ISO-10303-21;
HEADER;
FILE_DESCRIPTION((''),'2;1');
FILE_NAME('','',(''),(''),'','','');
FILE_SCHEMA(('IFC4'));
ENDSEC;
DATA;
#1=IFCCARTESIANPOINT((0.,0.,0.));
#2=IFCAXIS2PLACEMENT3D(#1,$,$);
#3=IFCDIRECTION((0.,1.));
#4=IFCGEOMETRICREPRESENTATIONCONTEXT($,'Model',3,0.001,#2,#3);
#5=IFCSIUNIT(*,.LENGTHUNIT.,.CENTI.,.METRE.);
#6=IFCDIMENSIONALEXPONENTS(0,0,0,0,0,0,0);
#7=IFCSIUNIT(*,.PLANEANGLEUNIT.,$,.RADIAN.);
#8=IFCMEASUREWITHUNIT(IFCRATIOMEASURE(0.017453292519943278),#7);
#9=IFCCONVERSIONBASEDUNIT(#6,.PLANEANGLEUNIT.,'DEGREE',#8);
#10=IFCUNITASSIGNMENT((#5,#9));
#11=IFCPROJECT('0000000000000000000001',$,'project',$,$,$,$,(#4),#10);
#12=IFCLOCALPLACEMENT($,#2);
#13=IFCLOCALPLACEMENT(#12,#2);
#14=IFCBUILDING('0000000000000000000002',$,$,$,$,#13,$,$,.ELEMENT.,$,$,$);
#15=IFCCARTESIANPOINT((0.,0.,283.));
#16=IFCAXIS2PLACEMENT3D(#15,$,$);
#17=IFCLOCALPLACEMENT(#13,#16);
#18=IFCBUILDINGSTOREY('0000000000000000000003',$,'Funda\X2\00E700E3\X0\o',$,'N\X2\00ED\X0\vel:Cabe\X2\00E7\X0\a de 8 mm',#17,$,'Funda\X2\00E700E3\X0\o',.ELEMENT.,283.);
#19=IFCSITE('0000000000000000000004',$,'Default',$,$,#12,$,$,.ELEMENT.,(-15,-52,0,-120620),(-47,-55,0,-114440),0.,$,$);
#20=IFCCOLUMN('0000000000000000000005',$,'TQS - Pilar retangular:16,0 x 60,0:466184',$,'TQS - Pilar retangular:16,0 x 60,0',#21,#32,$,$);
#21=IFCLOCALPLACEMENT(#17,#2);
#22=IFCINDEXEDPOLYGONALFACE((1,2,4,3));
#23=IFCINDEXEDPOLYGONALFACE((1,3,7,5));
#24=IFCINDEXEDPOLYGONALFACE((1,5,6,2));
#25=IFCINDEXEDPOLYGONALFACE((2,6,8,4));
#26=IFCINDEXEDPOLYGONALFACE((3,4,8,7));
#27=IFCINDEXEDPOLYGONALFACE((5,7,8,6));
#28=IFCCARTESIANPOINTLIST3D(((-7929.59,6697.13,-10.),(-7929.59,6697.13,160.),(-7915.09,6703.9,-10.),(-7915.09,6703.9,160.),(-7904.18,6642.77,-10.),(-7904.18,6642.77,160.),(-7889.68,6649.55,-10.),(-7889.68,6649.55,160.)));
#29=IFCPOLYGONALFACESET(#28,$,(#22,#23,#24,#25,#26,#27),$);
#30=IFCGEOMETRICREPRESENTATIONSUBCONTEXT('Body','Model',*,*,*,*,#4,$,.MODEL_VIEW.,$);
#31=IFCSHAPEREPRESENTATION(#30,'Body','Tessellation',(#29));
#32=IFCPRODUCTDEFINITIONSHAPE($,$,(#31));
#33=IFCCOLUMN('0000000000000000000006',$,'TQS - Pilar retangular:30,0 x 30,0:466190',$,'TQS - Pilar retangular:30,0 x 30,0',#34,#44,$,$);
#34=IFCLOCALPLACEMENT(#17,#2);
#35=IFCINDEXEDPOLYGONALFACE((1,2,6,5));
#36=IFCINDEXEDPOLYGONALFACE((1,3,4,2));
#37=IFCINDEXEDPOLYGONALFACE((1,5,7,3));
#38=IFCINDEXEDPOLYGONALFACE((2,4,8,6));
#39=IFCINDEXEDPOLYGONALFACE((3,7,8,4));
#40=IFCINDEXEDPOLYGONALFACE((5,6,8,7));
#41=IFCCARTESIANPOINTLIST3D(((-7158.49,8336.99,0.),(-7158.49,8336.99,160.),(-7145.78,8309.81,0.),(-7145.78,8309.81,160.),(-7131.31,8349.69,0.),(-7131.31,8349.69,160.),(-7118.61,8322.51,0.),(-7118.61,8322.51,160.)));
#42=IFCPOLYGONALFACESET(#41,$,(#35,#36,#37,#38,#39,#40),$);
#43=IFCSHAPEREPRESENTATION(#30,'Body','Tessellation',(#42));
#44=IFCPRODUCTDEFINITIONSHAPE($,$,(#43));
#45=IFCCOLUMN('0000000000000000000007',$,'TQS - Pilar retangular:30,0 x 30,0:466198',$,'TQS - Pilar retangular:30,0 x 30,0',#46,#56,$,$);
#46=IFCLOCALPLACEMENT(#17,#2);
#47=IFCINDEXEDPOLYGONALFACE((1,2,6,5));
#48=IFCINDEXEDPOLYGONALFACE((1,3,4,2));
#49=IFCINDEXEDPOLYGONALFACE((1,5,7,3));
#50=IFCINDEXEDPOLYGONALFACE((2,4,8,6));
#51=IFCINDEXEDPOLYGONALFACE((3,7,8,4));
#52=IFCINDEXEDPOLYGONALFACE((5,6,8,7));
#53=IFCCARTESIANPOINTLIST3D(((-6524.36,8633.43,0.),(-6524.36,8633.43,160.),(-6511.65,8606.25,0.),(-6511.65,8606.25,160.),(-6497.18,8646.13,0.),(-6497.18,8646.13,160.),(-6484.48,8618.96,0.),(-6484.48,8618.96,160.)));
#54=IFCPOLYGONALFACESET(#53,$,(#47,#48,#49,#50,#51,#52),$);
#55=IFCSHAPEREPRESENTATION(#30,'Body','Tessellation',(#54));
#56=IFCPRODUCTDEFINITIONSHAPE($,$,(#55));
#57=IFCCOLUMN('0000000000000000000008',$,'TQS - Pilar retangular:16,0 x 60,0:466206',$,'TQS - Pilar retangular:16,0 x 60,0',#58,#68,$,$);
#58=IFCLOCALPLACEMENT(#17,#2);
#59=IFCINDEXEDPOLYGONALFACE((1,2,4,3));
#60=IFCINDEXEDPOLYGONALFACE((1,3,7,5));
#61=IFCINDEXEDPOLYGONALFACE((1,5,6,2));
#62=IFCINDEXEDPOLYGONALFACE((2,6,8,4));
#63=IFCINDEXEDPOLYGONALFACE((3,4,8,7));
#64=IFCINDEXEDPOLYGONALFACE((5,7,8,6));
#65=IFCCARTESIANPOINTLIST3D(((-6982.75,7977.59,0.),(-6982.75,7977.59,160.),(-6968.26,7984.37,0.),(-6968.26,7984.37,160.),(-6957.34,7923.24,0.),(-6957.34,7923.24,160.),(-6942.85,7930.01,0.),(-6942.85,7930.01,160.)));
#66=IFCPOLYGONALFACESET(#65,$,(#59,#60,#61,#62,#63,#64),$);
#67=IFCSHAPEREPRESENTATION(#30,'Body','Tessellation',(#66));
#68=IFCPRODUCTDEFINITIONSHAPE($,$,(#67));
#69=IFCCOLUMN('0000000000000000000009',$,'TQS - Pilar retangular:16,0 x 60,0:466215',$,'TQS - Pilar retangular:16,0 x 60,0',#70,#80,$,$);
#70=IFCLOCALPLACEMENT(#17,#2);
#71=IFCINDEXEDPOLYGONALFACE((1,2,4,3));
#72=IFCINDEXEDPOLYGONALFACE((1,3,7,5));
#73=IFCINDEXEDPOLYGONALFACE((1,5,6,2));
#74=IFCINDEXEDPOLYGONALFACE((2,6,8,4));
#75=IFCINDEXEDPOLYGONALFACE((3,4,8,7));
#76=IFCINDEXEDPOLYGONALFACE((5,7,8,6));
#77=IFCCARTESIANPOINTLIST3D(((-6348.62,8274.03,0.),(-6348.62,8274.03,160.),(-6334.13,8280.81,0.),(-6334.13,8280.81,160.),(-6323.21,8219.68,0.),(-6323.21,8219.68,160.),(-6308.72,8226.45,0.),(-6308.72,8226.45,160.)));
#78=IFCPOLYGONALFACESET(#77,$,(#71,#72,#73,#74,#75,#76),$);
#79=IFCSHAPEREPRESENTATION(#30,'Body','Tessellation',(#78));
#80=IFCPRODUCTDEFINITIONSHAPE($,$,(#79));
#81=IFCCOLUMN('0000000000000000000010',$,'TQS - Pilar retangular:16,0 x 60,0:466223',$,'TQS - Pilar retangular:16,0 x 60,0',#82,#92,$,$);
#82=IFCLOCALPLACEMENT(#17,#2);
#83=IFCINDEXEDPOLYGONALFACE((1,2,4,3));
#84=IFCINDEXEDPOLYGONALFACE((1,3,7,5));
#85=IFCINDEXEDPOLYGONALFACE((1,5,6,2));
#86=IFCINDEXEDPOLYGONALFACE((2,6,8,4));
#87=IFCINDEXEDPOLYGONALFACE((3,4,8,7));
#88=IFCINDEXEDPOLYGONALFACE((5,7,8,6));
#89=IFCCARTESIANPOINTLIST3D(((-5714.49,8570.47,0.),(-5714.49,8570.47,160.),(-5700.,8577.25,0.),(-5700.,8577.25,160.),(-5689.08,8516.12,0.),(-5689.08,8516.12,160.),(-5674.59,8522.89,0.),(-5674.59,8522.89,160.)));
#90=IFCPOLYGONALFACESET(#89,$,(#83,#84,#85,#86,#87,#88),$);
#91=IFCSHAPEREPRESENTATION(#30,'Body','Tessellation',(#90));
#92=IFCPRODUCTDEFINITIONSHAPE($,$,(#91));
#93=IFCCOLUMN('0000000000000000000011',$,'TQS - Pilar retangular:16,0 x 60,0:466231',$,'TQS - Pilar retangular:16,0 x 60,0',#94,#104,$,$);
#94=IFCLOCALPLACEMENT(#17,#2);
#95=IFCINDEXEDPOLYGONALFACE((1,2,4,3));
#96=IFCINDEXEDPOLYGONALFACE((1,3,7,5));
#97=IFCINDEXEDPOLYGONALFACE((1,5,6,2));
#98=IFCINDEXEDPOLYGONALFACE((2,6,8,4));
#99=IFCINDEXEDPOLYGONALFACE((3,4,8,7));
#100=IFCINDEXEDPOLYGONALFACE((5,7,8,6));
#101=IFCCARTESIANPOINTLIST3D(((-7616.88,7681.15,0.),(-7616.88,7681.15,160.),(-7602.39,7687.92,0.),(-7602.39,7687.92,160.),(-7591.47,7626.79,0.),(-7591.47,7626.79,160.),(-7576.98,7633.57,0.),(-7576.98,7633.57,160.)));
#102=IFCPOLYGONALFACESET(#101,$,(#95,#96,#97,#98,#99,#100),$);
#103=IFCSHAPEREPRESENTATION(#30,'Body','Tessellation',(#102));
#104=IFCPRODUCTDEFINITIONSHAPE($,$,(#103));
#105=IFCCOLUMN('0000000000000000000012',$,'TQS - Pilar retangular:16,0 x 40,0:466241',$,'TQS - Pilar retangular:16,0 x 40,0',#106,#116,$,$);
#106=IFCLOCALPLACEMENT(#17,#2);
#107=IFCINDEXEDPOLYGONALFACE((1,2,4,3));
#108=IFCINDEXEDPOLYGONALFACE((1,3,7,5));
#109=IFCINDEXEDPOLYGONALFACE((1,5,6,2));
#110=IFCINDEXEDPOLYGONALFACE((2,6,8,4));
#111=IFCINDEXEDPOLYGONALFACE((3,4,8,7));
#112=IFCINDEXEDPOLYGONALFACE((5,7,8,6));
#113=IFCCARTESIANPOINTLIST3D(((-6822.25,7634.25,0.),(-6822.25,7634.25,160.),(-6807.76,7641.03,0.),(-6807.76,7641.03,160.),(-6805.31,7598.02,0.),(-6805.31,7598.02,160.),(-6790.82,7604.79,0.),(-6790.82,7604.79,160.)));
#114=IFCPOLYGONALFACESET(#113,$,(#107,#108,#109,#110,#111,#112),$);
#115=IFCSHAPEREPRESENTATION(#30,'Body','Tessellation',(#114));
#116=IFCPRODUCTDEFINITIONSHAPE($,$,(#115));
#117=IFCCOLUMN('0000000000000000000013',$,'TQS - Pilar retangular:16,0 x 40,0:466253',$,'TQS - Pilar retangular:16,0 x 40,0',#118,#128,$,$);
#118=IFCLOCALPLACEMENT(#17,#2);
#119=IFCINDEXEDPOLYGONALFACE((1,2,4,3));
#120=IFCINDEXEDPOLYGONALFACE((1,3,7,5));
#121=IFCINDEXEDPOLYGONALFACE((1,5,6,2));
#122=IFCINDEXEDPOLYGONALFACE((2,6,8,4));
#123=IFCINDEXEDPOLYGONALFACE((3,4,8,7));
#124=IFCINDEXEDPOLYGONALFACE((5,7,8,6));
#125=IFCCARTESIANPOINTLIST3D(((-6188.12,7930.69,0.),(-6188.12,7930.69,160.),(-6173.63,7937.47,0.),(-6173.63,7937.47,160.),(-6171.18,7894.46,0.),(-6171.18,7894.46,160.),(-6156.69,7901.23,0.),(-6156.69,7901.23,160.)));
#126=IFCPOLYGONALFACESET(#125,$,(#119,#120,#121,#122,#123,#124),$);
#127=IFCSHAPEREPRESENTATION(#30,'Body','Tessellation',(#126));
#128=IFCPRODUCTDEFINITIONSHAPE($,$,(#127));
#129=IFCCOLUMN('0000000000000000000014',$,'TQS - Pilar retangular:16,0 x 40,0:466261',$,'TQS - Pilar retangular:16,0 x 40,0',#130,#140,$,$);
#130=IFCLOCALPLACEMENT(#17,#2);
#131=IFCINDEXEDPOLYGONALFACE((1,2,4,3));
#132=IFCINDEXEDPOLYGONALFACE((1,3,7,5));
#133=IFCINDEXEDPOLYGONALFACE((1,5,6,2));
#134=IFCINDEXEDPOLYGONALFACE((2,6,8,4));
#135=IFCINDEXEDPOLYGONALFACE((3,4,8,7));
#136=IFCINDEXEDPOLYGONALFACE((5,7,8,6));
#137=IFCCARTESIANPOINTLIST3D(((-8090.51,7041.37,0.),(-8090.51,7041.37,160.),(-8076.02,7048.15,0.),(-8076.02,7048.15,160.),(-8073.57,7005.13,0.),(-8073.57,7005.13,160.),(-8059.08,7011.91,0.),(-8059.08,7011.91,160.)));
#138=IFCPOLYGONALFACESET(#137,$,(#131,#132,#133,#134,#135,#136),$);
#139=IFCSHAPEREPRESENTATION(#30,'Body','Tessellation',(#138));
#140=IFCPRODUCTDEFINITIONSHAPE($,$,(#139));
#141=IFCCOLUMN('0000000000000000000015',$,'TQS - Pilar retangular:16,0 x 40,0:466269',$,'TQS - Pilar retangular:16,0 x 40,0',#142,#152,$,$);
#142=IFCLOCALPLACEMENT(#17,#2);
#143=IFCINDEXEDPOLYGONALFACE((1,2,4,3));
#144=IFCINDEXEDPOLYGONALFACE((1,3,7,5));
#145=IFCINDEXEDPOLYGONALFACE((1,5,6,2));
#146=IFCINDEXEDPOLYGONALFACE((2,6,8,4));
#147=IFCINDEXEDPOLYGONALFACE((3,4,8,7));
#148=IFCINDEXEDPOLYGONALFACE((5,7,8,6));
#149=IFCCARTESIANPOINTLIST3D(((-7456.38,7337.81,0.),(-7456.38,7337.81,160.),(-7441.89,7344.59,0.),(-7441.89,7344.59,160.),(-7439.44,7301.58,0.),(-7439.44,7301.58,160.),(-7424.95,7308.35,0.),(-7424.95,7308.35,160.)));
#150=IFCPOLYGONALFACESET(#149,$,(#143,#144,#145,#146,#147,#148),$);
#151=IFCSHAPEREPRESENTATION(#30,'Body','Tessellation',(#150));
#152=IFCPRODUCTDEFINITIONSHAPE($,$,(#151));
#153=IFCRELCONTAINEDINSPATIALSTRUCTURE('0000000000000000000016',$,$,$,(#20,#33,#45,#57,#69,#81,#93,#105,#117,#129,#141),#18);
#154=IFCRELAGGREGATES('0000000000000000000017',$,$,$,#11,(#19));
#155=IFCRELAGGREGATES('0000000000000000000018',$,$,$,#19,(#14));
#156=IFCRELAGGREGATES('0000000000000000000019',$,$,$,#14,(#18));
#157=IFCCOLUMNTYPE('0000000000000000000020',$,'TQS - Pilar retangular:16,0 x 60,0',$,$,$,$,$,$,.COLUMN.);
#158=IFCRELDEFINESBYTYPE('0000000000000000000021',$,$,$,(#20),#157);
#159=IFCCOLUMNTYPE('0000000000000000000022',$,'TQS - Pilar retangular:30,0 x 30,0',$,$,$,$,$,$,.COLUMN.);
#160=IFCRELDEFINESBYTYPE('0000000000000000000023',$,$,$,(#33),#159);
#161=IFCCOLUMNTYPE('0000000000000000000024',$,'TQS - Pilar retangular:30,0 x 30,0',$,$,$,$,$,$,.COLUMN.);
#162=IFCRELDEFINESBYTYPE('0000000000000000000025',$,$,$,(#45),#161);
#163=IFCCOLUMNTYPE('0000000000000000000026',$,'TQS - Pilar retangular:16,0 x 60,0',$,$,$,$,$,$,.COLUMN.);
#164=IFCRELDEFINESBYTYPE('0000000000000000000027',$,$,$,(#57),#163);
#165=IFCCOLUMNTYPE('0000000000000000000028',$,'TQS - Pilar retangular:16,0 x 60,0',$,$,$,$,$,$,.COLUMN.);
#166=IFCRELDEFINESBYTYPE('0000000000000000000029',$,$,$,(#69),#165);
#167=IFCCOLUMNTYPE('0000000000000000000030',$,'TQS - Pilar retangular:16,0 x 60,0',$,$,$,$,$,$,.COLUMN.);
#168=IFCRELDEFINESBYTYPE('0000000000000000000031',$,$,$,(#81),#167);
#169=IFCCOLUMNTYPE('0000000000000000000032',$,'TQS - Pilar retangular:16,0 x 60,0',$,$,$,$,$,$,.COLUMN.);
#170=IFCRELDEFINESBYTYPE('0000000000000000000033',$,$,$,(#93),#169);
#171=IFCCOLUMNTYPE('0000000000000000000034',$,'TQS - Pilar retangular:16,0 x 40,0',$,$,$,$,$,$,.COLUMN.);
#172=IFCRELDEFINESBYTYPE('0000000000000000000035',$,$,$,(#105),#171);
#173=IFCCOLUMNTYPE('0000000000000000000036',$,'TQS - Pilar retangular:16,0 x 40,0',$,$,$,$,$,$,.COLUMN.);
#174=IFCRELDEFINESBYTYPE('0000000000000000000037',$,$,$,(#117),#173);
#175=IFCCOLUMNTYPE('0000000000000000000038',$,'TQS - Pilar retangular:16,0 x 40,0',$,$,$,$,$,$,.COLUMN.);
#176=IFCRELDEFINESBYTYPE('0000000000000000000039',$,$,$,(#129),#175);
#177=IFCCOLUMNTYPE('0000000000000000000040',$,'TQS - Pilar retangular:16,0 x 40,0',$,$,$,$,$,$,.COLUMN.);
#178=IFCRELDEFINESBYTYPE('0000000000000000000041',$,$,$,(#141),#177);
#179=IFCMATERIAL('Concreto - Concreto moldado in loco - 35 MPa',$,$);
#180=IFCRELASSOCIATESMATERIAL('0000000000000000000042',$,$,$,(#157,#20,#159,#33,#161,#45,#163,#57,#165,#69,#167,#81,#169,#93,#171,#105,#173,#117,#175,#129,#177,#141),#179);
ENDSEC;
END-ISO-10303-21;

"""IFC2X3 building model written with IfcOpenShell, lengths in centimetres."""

from ifc_helpers import new_model, entity, si_unit, converted_unit, direction, frame, frame_2d, origin, origin_2d_with_axis, place, context, subcontext, project, spatial, rectangle, extrude, source, transform, mapped, material, type_object, type_shapes, element, save


model = new_model("IFC2X3")

# Units and contexts
model_context = context("Model", 3, precision=0.001, world=origin(), true_north=direction((0.0, 1.0)))
body_context = subcontext(model_context, "Body", "Model", "MODEL_VIEW")
ifc_project = project(units=[si_unit("LENGTHUNIT", "METRE", prefix="CENTI"), converted_unit("PLANEANGLEUNIT", "DEGREE", entity("IfcRatioMeasure", 0.017453292519943278), si_unit("PLANEANGLEUNIT", "RADIAN"), dimensions=[0, 0, 0, 0, 0, 0, 0])], contexts=[model_context])

# Site, building, storey
site_placement = place(None, origin())
site = spatial("IfcSite", under=ifc_project, at=site_placement, Name="Default", CompositionType="ELEMENT", RefLatitude=(-15, -52, 0, -120620), RefLongitude=(-47, -55, 0, -114440), RefElevation=0.0)
building_placement = place(site_placement, origin())
building = spatial("IfcBuilding", under=site, at=building_placement, CompositionType="ELEMENT")
storey_placement = place(building_placement, frame((0.0, 0.0, 283.0)))
storey = spatial("IfcBuildingStorey", under=building, at=storey_placement, Name="Fundação", ObjectType="Nível:Cabeça de 8 mm", LongName="Fundação", CompositionType="ELEMENT", Elevation=283.0)

# Columns
ifc_material_1 = material(Name="Concreto - Concreto moldado in loco - 35 MPa")
column_type_1 = type_object("IfcColumnType", Name="TQS - Pilar retangular:16,0 x 60,0", PredefinedType="COLUMN", material=ifc_material_1)
shared_shape_1 = source(origin(), body_context, "Body", "SweptSolid", [
    extrude(rectangle(XDim=60.0, YDim=16.0, at=origin_2d_with_axis()), frame((-7909.64, 6673.34, 273.0), z_axis=(0.0, 0.0, 1.0), x_axis=(-0.423488, 0.905902, 0.0)), (0.0, 0.0, 1.0), 170.0),
])
type_shapes(column_type_1, [shared_shape_1])
column_1_placement = place(storey_placement, frame((0.0, 0.0, -283.0)))
element("IfcColumn", 1, at=column_1_placement, inside=storey, type_object=column_type_1, material=ifc_material_1, Name="TQS - Pilar retangular:16,0 x 60,0:466184", ObjectType="TQS - Pilar retangular:16,0 x 60,0", context=body_context, shape_type="MappedRepresentation", body=[
    mapped(shared_shape_1, transform((0.0, 0.0, 0.0), scale=1.0)),
])
column_type_2 = type_object("IfcColumnType", Name="TQS - Pilar retangular:30,0 x 30,0", PredefinedType="COLUMN", material=ifc_material_1)
shared_shape_2 = source(origin(), body_context, "Body", "SweptSolid", [
    extrude(rectangle(XDim=30.0, YDim=30.0, at=origin_2d_with_axis()), frame((-7138.55, 8329.75, 283.0), z_axis=(0.0, 0.0, 1.0), x_axis=(-0.423488, 0.905902, 0.0)), (0.0, 0.0, 1.0), 160.0),
])
type_shapes(column_type_2, [shared_shape_2])
column_2_placement = place(storey_placement, frame((0.0, 0.0, -283.0)))
element("IfcColumn", 2, at=column_2_placement, inside=storey, type_object=column_type_2, material=ifc_material_1, Name="TQS - Pilar retangular:30,0 x 30,0:466190", ObjectType="TQS - Pilar retangular:30,0 x 30,0", context=body_context, shape_type="MappedRepresentation", body=[
    mapped(shared_shape_2, transform((0.0, 0.0, 0.0), scale=1.0)),
])
column_type_3 = type_object("IfcColumnType", Name="TQS - Pilar retangular:30,0 x 30,0", PredefinedType="COLUMN", material=ifc_material_1)
shared_shape_3 = source(origin(), body_context, "Body", "SweptSolid", [
    extrude(rectangle(XDim=30.0, YDim=30.0, at=origin_2d_with_axis()), frame((-6504.42, 8626.19, 283.0), z_axis=(0.0, 0.0, 1.0), x_axis=(-0.423488, 0.905902, 0.0)), (0.0, 0.0, 1.0), 160.0),
])
type_shapes(column_type_3, [shared_shape_3])
column_3_placement = place(storey_placement, frame((0.0, 0.0, -283.0)))
element("IfcColumn", 3, at=column_3_placement, inside=storey, type_object=column_type_3, material=ifc_material_1, Name="TQS - Pilar retangular:30,0 x 30,0:466198", ObjectType="TQS - Pilar retangular:30,0 x 30,0", context=body_context, shape_type="MappedRepresentation", body=[
    mapped(shared_shape_3, transform((0.0, 0.0, 0.0), scale=1.0)),
])
column_type_4 = type_object("IfcColumnType", Name="TQS - Pilar retangular:16,0 x 60,0", PredefinedType="COLUMN", material=ifc_material_1)
shared_shape_4 = source(origin(), body_context, "Body", "SweptSolid", [
    extrude(rectangle(XDim=60.0, YDim=16.0, at=frame_2d((0.0, 0.0), x_axis=(1.0, 0.0))), frame((-6962.8, 7953.8, 283.0), z_axis=(0.0, 0.0, 1.0), x_axis=(-0.423488, 0.905902, 0.0)), (0.0, 0.0, 1.0), 160.0),
])
type_shapes(column_type_4, [shared_shape_4])
column_4_placement = place(storey_placement, frame((0.0, 0.0, -283.0)))
element("IfcColumn", 4, at=column_4_placement, inside=storey, type_object=column_type_4, material=ifc_material_1, Name="TQS - Pilar retangular:16,0 x 60,0:466206", ObjectType="TQS - Pilar retangular:16,0 x 60,0", context=body_context, shape_type="MappedRepresentation", body=[
    mapped(shared_shape_4, transform((0.0, 0.0, 0.0), scale=1.0)),
])
column_type_5 = type_object("IfcColumnType", Name="TQS - Pilar retangular:16,0 x 60,0", PredefinedType="COLUMN", material=ifc_material_1)
shared_shape_5 = source(origin(), body_context, "Body", "SweptSolid", [
    extrude(rectangle(XDim=60.0, YDim=16.0, at=origin_2d_with_axis()), frame((-6328.67, 8250.24, 283.0), z_axis=(0.0, 0.0, 1.0), x_axis=(-0.423488, 0.905902, 0.0)), (0.0, 0.0, 1.0), 160.0),
])
type_shapes(column_type_5, [shared_shape_5])
column_5_placement = place(storey_placement, frame((0.0, 0.0, -283.0)))
element("IfcColumn", 5, at=column_5_placement, inside=storey, type_object=column_type_5, material=ifc_material_1, Name="TQS - Pilar retangular:16,0 x 60,0:466215", ObjectType="TQS - Pilar retangular:16,0 x 60,0", context=body_context, shape_type="MappedRepresentation", body=[
    mapped(shared_shape_5, transform((0.0, 0.0, 0.0), scale=1.0)),
])
column_type_6 = type_object("IfcColumnType", Name="TQS - Pilar retangular:16,0 x 60,0", PredefinedType="COLUMN", material=ifc_material_1)
shared_shape_6 = source(origin(), body_context, "Body", "SweptSolid", [
    extrude(rectangle(XDim=60.0, YDim=16.0, at=frame_2d((0.0, 0.0), x_axis=(1.0, 0.0))), frame((-5694.54, 8546.68, 283.0), z_axis=(0.0, 0.0, 1.0), x_axis=(-0.423488, 0.905902, 0.0)), (0.0, 0.0, 1.0), 160.0),
])
type_shapes(column_type_6, [shared_shape_6])
column_6_placement = place(storey_placement, frame((0.0, 0.0, -283.0)))
element("IfcColumn", 6, at=column_6_placement, inside=storey, type_object=column_type_6, material=ifc_material_1, Name="TQS - Pilar retangular:16,0 x 60,0:466223", ObjectType="TQS - Pilar retangular:16,0 x 60,0", context=body_context, shape_type="MappedRepresentation", body=[
    mapped(shared_shape_6, transform((0.0, 0.0, 0.0), scale=1.0)),
])
column_type_7 = type_object("IfcColumnType", Name="TQS - Pilar retangular:16,0 x 60,0", PredefinedType="COLUMN", material=ifc_material_1)
shared_shape_7 = source(origin(), body_context, "Body", "SweptSolid", [
    extrude(rectangle(XDim=60.0, YDim=16.0, at=frame_2d((0.0, 0.0), x_axis=(1.0, 0.0))), frame((-7596.93, 7657.36, 283.0), z_axis=(0.0, 0.0, 1.0), x_axis=(-0.423488, 0.905902, 0.0)), (0.0, 0.0, 1.0), 160.0),
])
type_shapes(column_type_7, [shared_shape_7])
column_7_placement = place(storey_placement, frame((0.0, 0.0, -283.0)))
element("IfcColumn", 7, at=column_7_placement, inside=storey, type_object=column_type_7, material=ifc_material_1, Name="TQS - Pilar retangular:16,0 x 60,0:466231", ObjectType="TQS - Pilar retangular:16,0 x 60,0", context=body_context, shape_type="MappedRepresentation", body=[
    mapped(shared_shape_7, transform((0.0, 0.0, 0.0), scale=1.0)),
])
column_type_8 = type_object("IfcColumnType", Name="TQS - Pilar retangular:16,0 x 40,0", PredefinedType="COLUMN", material=ifc_material_1)
shared_shape_8 = source(origin(), body_context, "Body", "SweptSolid", [
    extrude(rectangle(XDim=40.0, YDim=16.0, at=origin_2d_with_axis()), frame((-6806.53, 7619.52, 283.0), z_axis=(0.0, 0.0, 1.0), x_axis=(-0.423488, 0.905902, 0.0)), (0.0, 0.0, 1.0), 160.0),
])
type_shapes(column_type_8, [shared_shape_8])
column_8_placement = place(storey_placement, frame((0.0, 0.0, -283.0)))
element("IfcColumn", 8, at=column_8_placement, inside=storey, type_object=column_type_8, material=ifc_material_1, Name="TQS - Pilar retangular:16,0 x 40,0:466241", ObjectType="TQS - Pilar retangular:16,0 x 40,0", context=body_context, shape_type="MappedRepresentation", body=[
    mapped(shared_shape_8, transform((0.0, 0.0, 0.0), scale=1.0)),
])
column_type_9 = type_object("IfcColumnType", Name="TQS - Pilar retangular:16,0 x 40,0", PredefinedType="COLUMN", material=ifc_material_1)
shared_shape_9 = source(origin(), body_context, "Body", "SweptSolid", [
    extrude(rectangle(XDim=40.0, YDim=16.0, at=origin_2d_with_axis()), frame((-6172.4, 7915.96, 283.0), z_axis=(0.0, 0.0, 1.0), x_axis=(-0.423488, 0.905902, 0.0)), (0.0, 0.0, 1.0), 160.0),
])
type_shapes(column_type_9, [shared_shape_9])
column_9_placement = place(storey_placement, frame((0.0, 0.0, -283.0)))
element("IfcColumn", 9, at=column_9_placement, inside=storey, type_object=column_type_9, material=ifc_material_1, Name="TQS - Pilar retangular:16,0 x 40,0:466253", ObjectType="TQS - Pilar retangular:16,0 x 40,0", context=body_context, shape_type="MappedRepresentation", body=[
    mapped(shared_shape_9, transform((0.0, 0.0, 0.0), scale=1.0)),
])
column_type_10 = type_object("IfcColumnType", Name="TQS - Pilar retangular:16,0 x 40,0", PredefinedType="COLUMN", material=ifc_material_1)
shared_shape_10 = source(origin(), body_context, "Body", "SweptSolid", [
    extrude(rectangle(XDim=40.0, YDim=16.0, at=origin_2d_with_axis()), frame((-8074.8, 7026.64, 283.0), z_axis=(0.0, 0.0, 1.0), x_axis=(-0.423488, 0.905902, 0.0)), (0.0, 0.0, 1.0), 160.0),
])
type_shapes(column_type_10, [shared_shape_10])
column_10_placement = place(storey_placement, frame((0.0, 0.0, -283.0)))
element("IfcColumn", 10, at=column_10_placement, inside=storey, type_object=column_type_10, material=ifc_material_1, Name="TQS - Pilar retangular:16,0 x 40,0:466261", ObjectType="TQS - Pilar retangular:16,0 x 40,0", context=body_context, shape_type="MappedRepresentation", body=[
    mapped(shared_shape_10, transform((0.0, 0.0, 0.0), scale=1.0)),
])
column_type_11 = type_object("IfcColumnType", Name="TQS - Pilar retangular:16,0 x 40,0", PredefinedType="COLUMN", material=ifc_material_1)
shared_shape_11 = source(origin(), body_context, "Body", "SweptSolid", [
    extrude(rectangle(XDim=40.0, YDim=16.0, at=origin_2d_with_axis()), frame((-7440.67, 7323.08, 283.0), z_axis=(0.0, 0.0, 1.0), x_axis=(-0.423488, 0.905902, 0.0)), (0.0, 0.0, 1.0), 160.0),
])
type_shapes(column_type_11, [shared_shape_11])
column_11_placement = place(storey_placement, frame((0.0, 0.0, -283.0)))
element("IfcColumn", 11, at=column_11_placement, inside=storey, type_object=column_type_11, material=ifc_material_1, Name="TQS - Pilar retangular:16,0 x 40,0:466269", ObjectType="TQS - Pilar retangular:16,0 x 40,0", context=body_context, shape_type="MappedRepresentation", body=[
    mapped(shared_shape_11, transform((0.0, 0.0, 0.0), scale=1.0)),
])

save(model, "model.ifc")
